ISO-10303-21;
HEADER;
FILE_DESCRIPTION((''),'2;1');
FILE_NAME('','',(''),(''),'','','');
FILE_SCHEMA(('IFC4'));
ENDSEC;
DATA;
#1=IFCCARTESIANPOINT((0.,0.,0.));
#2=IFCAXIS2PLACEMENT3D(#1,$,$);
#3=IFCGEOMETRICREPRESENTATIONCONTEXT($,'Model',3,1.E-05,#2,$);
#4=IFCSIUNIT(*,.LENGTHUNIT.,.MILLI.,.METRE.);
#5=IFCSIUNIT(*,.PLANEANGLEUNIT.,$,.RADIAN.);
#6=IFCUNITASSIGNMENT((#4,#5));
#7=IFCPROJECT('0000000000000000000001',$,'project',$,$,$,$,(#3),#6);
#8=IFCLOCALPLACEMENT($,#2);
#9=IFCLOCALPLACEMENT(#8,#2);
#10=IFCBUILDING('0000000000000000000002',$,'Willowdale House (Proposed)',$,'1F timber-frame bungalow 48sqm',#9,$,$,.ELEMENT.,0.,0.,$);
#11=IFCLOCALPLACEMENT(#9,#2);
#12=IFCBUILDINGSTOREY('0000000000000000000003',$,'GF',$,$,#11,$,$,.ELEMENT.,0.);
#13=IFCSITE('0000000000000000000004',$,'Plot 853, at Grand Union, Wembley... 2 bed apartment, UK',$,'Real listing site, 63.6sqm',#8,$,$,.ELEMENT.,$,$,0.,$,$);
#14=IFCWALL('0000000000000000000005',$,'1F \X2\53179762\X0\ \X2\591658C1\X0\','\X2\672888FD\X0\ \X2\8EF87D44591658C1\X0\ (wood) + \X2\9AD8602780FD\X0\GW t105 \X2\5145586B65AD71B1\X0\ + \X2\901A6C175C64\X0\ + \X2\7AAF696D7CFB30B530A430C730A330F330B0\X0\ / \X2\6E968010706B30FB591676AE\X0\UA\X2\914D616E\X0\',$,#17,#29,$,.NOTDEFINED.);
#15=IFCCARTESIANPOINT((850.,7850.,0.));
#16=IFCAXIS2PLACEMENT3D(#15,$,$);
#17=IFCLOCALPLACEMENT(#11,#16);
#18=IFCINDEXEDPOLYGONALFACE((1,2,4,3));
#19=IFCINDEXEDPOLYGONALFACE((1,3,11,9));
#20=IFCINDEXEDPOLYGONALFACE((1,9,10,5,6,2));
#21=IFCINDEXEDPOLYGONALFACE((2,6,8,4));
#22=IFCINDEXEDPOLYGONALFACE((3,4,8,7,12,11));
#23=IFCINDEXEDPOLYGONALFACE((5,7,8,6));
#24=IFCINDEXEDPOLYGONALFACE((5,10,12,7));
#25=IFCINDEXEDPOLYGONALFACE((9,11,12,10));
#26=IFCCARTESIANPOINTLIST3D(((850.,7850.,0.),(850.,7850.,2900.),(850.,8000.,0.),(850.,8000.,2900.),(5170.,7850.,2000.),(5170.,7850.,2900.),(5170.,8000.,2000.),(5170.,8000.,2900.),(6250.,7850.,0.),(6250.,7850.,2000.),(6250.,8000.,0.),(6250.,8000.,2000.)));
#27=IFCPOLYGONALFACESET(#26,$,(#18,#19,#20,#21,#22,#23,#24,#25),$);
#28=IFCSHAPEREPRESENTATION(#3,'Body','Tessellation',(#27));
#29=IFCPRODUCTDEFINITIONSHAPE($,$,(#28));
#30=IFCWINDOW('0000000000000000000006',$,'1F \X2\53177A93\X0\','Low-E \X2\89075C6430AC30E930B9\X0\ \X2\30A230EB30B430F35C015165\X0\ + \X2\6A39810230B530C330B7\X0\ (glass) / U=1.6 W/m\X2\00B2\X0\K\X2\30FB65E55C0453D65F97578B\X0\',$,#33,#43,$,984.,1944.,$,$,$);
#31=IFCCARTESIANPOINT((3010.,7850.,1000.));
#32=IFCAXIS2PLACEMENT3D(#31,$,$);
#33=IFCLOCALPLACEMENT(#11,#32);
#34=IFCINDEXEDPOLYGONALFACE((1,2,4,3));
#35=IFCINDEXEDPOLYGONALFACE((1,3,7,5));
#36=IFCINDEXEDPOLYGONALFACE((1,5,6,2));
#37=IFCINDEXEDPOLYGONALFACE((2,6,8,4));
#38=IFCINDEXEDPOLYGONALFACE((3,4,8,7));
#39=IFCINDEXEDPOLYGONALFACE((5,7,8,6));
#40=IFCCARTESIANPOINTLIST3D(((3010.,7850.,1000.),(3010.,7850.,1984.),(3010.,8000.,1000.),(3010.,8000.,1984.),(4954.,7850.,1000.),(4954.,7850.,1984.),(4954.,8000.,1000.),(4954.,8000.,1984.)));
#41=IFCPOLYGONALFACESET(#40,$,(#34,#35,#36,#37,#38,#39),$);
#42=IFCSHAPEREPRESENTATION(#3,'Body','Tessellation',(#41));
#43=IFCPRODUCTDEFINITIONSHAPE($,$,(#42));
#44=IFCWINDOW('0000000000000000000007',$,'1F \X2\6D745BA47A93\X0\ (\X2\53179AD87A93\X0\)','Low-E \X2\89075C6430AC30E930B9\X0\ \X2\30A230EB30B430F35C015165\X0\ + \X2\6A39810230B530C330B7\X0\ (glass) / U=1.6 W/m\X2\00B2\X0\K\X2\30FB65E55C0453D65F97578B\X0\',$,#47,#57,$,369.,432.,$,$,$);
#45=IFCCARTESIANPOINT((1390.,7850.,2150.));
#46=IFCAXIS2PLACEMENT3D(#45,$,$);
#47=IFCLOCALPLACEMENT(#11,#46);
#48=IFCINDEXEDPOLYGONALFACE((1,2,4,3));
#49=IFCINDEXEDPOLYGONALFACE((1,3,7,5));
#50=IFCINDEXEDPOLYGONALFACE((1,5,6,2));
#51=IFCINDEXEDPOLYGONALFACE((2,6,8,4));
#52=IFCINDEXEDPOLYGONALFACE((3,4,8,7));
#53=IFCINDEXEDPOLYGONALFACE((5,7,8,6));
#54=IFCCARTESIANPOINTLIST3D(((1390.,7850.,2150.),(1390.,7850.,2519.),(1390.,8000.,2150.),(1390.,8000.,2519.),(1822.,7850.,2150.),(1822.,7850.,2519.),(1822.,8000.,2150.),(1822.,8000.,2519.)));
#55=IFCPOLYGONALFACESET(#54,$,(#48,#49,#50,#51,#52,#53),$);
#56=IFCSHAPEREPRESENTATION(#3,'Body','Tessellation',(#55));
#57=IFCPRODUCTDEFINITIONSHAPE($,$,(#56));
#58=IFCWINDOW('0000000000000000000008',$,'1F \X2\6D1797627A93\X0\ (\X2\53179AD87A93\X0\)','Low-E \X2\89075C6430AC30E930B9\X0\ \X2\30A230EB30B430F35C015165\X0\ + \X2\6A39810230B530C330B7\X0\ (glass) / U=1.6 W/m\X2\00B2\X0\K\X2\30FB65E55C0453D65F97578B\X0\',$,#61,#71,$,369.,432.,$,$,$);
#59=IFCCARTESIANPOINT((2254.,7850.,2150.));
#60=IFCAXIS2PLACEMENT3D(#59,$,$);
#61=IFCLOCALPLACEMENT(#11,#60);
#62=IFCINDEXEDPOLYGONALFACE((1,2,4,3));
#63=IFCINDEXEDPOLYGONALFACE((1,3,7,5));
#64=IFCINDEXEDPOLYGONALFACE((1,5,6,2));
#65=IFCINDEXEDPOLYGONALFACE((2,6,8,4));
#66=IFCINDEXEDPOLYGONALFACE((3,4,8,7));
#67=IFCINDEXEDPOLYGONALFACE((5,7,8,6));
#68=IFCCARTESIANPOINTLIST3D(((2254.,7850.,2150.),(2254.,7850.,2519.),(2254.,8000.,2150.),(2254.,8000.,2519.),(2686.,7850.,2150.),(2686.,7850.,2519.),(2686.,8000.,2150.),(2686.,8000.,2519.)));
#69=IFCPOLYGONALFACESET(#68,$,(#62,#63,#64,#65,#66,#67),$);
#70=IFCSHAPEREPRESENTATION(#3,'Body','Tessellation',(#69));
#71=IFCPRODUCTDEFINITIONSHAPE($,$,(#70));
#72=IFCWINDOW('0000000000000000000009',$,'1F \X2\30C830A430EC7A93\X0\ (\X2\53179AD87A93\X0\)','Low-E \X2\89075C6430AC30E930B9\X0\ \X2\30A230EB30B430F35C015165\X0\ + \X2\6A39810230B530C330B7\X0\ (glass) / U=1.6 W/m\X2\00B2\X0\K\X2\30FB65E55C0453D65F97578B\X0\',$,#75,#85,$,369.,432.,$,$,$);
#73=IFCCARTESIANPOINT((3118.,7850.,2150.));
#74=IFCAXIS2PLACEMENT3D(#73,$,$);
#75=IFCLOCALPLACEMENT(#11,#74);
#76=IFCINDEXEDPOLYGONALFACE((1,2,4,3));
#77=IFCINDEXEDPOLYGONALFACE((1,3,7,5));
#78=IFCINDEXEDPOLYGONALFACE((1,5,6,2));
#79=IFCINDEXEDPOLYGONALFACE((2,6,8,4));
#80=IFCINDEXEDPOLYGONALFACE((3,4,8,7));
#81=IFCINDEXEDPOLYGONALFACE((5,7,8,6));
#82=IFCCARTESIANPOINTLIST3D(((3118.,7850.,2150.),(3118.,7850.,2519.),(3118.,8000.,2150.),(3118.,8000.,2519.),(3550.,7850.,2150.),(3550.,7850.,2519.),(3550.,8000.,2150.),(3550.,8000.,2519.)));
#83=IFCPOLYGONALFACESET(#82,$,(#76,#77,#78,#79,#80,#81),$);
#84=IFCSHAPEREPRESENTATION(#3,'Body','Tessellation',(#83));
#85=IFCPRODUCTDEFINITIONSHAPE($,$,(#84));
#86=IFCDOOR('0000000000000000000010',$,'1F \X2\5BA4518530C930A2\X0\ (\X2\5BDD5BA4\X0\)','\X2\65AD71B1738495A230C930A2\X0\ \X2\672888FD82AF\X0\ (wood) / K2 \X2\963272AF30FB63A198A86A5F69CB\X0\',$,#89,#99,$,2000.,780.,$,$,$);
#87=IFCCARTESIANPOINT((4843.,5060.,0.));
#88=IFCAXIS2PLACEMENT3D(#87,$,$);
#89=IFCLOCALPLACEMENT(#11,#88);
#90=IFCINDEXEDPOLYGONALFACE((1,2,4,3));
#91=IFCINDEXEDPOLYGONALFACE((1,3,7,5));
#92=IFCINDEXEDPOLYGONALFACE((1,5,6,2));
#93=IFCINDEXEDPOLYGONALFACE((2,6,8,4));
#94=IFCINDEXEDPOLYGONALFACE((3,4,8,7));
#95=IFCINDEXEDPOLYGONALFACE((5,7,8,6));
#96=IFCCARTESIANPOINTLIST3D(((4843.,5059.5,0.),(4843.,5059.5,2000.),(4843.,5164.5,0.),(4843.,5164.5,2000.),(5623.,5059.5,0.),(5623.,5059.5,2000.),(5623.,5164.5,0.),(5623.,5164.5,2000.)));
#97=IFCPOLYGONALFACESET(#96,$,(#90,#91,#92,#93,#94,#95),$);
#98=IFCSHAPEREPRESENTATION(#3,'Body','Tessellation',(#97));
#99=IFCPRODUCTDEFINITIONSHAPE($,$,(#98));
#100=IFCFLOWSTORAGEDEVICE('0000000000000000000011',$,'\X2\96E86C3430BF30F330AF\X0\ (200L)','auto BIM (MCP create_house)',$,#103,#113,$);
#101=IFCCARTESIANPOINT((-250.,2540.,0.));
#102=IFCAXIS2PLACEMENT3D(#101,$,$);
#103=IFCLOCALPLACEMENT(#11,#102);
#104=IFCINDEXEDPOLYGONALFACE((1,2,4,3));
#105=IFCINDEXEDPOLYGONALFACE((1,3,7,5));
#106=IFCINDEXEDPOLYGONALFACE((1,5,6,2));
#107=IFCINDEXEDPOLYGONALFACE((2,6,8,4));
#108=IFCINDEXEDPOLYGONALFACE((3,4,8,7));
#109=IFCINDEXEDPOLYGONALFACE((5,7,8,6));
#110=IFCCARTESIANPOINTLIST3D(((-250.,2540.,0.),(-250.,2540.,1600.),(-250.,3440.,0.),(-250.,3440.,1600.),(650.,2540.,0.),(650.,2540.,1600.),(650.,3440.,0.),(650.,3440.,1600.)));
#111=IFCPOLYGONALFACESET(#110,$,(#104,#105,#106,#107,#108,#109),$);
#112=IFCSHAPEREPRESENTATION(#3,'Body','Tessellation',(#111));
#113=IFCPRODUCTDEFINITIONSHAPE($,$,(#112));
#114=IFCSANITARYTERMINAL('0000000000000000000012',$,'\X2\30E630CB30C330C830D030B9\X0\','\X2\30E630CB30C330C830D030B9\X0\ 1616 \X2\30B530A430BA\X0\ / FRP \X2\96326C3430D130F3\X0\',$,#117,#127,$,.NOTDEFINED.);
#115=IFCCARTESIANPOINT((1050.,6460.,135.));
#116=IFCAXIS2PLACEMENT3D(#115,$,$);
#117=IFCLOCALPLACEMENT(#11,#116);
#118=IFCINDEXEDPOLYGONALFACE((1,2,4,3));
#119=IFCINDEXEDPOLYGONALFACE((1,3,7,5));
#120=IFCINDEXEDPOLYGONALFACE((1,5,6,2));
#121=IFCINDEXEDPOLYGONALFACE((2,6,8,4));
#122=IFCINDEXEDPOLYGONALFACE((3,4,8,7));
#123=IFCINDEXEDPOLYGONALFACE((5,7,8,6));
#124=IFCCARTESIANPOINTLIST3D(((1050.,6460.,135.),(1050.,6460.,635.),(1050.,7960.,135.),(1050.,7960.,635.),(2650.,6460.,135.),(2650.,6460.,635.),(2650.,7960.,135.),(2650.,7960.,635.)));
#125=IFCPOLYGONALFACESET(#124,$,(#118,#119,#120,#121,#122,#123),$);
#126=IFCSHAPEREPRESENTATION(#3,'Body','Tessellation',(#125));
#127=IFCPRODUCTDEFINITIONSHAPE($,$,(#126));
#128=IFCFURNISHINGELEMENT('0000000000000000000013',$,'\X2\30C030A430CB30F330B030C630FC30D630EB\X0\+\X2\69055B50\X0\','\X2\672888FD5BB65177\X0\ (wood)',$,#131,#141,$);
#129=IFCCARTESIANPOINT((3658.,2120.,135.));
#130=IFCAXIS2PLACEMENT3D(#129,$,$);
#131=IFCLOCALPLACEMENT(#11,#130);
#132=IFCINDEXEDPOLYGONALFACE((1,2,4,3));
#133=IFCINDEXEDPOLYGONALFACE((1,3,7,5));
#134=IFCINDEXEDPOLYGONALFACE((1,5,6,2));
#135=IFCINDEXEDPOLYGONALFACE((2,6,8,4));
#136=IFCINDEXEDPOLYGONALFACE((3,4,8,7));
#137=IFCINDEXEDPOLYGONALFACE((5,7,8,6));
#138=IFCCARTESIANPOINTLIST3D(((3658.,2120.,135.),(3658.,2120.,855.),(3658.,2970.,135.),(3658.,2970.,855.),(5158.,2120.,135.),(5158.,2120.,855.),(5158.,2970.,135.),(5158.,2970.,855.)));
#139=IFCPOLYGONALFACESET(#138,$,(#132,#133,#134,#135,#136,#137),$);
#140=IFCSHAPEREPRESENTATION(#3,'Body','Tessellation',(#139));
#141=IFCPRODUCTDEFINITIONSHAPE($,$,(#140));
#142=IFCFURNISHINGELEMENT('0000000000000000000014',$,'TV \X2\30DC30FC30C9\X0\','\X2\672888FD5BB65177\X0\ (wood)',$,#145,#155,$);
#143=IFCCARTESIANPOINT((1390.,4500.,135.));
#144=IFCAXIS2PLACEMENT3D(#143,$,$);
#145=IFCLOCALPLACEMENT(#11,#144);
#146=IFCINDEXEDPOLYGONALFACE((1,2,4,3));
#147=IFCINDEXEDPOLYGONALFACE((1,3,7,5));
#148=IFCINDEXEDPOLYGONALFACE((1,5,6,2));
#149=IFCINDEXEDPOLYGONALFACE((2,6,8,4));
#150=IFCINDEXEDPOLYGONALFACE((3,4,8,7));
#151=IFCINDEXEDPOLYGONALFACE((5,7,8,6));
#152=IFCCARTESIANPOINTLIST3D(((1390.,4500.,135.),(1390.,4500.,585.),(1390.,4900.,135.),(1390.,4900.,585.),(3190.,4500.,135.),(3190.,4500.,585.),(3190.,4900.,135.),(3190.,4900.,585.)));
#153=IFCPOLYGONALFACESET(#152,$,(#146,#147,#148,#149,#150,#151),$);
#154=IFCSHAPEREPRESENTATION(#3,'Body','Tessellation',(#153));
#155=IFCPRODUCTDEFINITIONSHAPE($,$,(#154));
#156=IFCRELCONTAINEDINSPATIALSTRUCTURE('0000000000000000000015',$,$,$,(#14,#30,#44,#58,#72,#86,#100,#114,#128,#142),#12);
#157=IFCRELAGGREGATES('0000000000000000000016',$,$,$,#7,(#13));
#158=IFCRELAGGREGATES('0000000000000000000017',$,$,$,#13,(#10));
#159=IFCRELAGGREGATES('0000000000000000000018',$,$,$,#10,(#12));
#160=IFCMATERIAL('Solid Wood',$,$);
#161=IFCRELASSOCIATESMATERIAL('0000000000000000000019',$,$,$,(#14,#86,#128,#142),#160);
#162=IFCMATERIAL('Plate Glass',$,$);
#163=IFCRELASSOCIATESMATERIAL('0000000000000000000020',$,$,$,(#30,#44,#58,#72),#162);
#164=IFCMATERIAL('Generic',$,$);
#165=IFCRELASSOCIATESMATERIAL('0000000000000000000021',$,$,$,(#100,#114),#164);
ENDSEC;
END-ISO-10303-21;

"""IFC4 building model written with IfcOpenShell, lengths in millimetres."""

from ifc_helpers import new_model, si_unit, frame, frame_2d, origin, place, context, project, spatial, rectangle, extrude, material, element, fill, save


model = new_model("IFC4")

# Units and contexts
model_context = context("Model", 3, precision=1e-05, world=origin())
ifc_project = project(units=[si_unit("LENGTHUNIT", "METRE", prefix="MILLI"), si_unit("PLANEANGLEUNIT", "RADIAN")], contexts=[model_context])

# Site, building, storey
site_placement = place(None, origin())
site = spatial("IfcSite", under=ifc_project, at=site_placement, Name="Plot 853, at Grand Union, Wembley... 2 bed apartment, UK", ObjectType="Real listing site, 63.6sqm", CompositionType="ELEMENT", RefElevation=0.0)
building_placement = place(site_placement, origin())
building = spatial("IfcBuilding", under=site, at=building_placement, Name="Willowdale House (Proposed)", ObjectType="1F timber-frame bungalow 48sqm", CompositionType="ELEMENT", ElevationOfRefHeight=0.0, ElevationOfTerrain=0.0)
storey_placement = place(building_placement, origin())
storey = spatial("IfcBuildingStorey", under=building, at=storey_placement, Name="GF", CompositionType="ELEMENT", Elevation=0.0)

# Wall, openings, windows
ifc_material_1 = material(Name="Solid Wood")
wall_1_placement = place(storey_placement, frame((850.0, 7850.0, 0.0)))
wall_1 = element("IfcWall", 1, at=wall_1_placement, inside=storey, material=ifc_material_1, Name="1F 北面 外壁", Description="木製 軸組外壁 (wood) + 高性能GW t105 充填断熱 + 通気層 + 窯業系サイディング / 準耐火・外皮UA配慮", PredefinedType="NOTDEFINED", context=model_context, shape_type="SweptSolid", body=[
    extrude(rectangle(XDim=5400.0, YDim=150.0, at=frame_2d((2700.0, 75.0))), frame((850.0, 7850.0, 0.0)), (0.0, 0.0, 1.0), 2900.0),
])
opening_1_placement = place(storey_placement, frame((3010.0, 7850.0, 1000.0)))
opening_1 = element("IfcOpeningElement", 2, at=opening_1_placement, cuts=wall_1, PredefinedType="NOTDEFINED", context=model_context, shape_type="SweptSolid", body=[
    extrude(rectangle(XDim=1944.0, YDim=150.0, at=frame_2d((972.0, 75.0))), frame((3010.0, 7850.0, 1000.0)), (0.0, 0.0, 1.0), 984.0),
])
opening_2_placement = place(storey_placement, frame((1390.0, 7850.0, 2150.0)))
opening_2 = element("IfcOpeningElement", 3, at=opening_2_placement, cuts=wall_1, PredefinedType="NOTDEFINED", context=model_context, shape_type="SweptSolid", body=[
    extrude(rectangle(XDim=432.0, YDim=150.0, at=frame_2d((216.0, 75.0))), frame((1390.0, 7850.0, 2150.0)), (0.0, 0.0, 1.0), 369.0),
])
opening_3_placement = place(storey_placement, frame((2254.0, 7850.0, 2150.0)))
opening_3 = element("IfcOpeningElement", 4, at=opening_3_placement, cuts=wall_1, PredefinedType="NOTDEFINED", context=model_context, shape_type="SweptSolid", body=[
    extrude(rectangle(XDim=432.0, YDim=150.0, at=frame_2d((216.0, 75.0))), frame((2254.0, 7850.0, 2150.0)), (0.0, 0.0, 1.0), 369.0),
])
opening_4_placement = place(storey_placement, frame((3118.0, 7850.0, 2150.0)))
opening_4 = element("IfcOpeningElement", 5, at=opening_4_placement, cuts=wall_1, PredefinedType="NOTDEFINED", context=model_context, shape_type="SweptSolid", body=[
    extrude(rectangle(XDim=432.0, YDim=150.0, at=frame_2d((216.0, 75.0))), frame((3118.0, 7850.0, 2150.0)), (0.0, 0.0, 1.0), 369.0),
])
ifc_material_2 = material(Name="Plate Glass")
window_1_placement = place(storey_placement, frame((3010.0, 7850.0, 1000.0)))
window_1 = element("IfcWindow", 6, at=window_1_placement, inside=storey, material=ifc_material_2, Name="1F 北窓", Description="Low-E 複層ガラス アルゴン封入 + 樹脂サッシ (glass) / U=1.6 W/m²K・日射取得型", OverallHeight=984.0, OverallWidth=1944.0, context=model_context, shape_type="SweptSolid", body=[
    extrude(rectangle(XDim=1944.0, YDim=150.0, at=frame_2d((972.0, 75.0))), frame((3010.0, 7850.0, 1000.0)), (0.0, 0.0, 1.0), 984.0),
])
fill(opening_1, window_1)
window_2_placement = place(storey_placement, frame((1390.0, 7850.0, 2150.0)))
window_2 = element("IfcWindow", 7, at=window_2_placement, inside=storey, material=ifc_material_2, Name="1F 浴室窓 (北高窓)", Description="Low-E 複層ガラス アルゴン封入 + 樹脂サッシ (glass) / U=1.6 W/m²K・日射取得型", OverallHeight=369.0, OverallWidth=432.0, context=model_context, shape_type="SweptSolid", body=[
    extrude(rectangle(XDim=432.0, YDim=150.0, at=frame_2d((216.0, 75.0))), frame((1390.0, 7850.0, 2150.0)), (0.0, 0.0, 1.0), 369.0),
])
fill(opening_2, window_2)
window_3_placement = place(storey_placement, frame((2254.0, 7850.0, 2150.0)))
window_3 = element("IfcWindow", 8, at=window_3_placement, inside=storey, material=ifc_material_2, Name="1F 洗面窓 (北高窓)", Description="Low-E 複層ガラス アルゴン封入 + 樹脂サッシ (glass) / U=1.6 W/m²K・日射取得型", OverallHeight=369.0, OverallWidth=432.0, context=model_context, shape_type="SweptSolid", body=[
    extrude(rectangle(XDim=432.0, YDim=150.0, at=frame_2d((216.0, 75.0))), frame((2254.0, 7850.0, 2150.0)), (0.0, 0.0, 1.0), 369.0),
])
fill(opening_3, window_3)
window_4_placement = place(storey_placement, frame((3118.0, 7850.0, 2150.0)))
window_4 = element("IfcWindow", 9, at=window_4_placement, inside=storey, material=ifc_material_2, Name="1F トイレ窓 (北高窓)", Description="Low-E 複層ガラス アルゴン封入 + 樹脂サッシ (glass) / U=1.6 W/m²K・日射取得型", OverallHeight=369.0, OverallWidth=432.0, context=model_context, shape_type="SweptSolid", body=[
    extrude(rectangle(XDim=432.0, YDim=150.0, at=frame_2d((216.0, 75.0))), frame((3118.0, 7850.0, 2150.0)), (0.0, 0.0, 1.0), 369.0),
])
fill(opening_4, window_4)

# Door
door_1_placement = place(storey_placement, frame((4843.0, 5060.0, 0.0)))
element("IfcDoor", 10, at=door_1_placement, inside=storey, material=ifc_material_1, Name="1F 室内ドア (寝室)", Description="断熱玄関ドア 木製芯 (wood) / K2 防犯・採風機構", OverallHeight=2000.0, OverallWidth=780.0, context=model_context, shape_type="SweptSolid", body=[
    extrude(rectangle(XDim=780.0, YDim=105.0, at=frame_2d((390.0, 52.0))), frame((4843.0, 5060.0, 0.0)), (0.0, 0.0, 1.0), 2000.0),
])

# Flow storage device
ifc_material_3 = material(Name="Generic")
flow_storage_device_placement = place(storey_placement, frame((-250.0, 2540.0, 0.0)))
element("IfcFlowStorageDevice", 11, at=flow_storage_device_placement, inside=storey, material=ifc_material_3, Name="雨水タンク (200L)", Description="auto BIM (MCP create_house)", context=model_context, shape_type="SweptSolid", body=[
    extrude(rectangle(XDim=900.0, YDim=900.0, at=frame_2d((450.0, 450.0))), frame((-250.0, 2540.0, 0.0)), (0.0, 0.0, 1.0), 1600.0),
])

# Sanitary terminal
sanitary_terminal_placement = place(storey_placement, frame((1050.0, 6460.0, 135.0)))
element("IfcSanitaryTerminal", 12, at=sanitary_terminal_placement, inside=storey, material=ifc_material_3, Name="ユニットバス", Description="ユニットバス 1616 サイズ / FRP 防水パン", PredefinedType="NOTDEFINED", context=model_context, shape_type="SweptSolid", body=[
    extrude(rectangle(XDim=1600.0, YDim=1500.0, at=frame_2d((800.0, 750.0))), frame((1050.0, 6460.0, 135.0)), (0.0, 0.0, 1.0), 500.0),
])

# Furnishing elements
furnishing_1_placement = place(storey_placement, frame((3658.0, 2120.0, 135.0)))
element("IfcFurnishingElement", 13, at=furnishing_1_placement, inside=storey, material=ifc_material_1, Name="ダイニングテーブル+椅子", Description="木製家具 (wood)", context=model_context, shape_type="SweptSolid", body=[
    extrude(rectangle(XDim=1500.0, YDim=850.0, at=frame_2d((750.0, 425.0))), frame((3658.0, 2120.0, 135.0)), (0.0, 0.0, 1.0), 720.0),
])
furnishing_2_placement = place(storey_placement, frame((1390.0, 4500.0, 135.0)))
element("IfcFurnishingElement", 14, at=furnishing_2_placement, inside=storey, material=ifc_material_1, Name="TV ボード", Description="木製家具 (wood)", context=model_context, shape_type="SweptSolid", body=[
    extrude(rectangle(XDim=1800.0, YDim=400.0, at=frame_2d((900.0, 200.0))), frame((1390.0, 4500.0, 135.0)), (0.0, 0.0, 1.0), 450.0),
])

save(model, "model.ifc")
